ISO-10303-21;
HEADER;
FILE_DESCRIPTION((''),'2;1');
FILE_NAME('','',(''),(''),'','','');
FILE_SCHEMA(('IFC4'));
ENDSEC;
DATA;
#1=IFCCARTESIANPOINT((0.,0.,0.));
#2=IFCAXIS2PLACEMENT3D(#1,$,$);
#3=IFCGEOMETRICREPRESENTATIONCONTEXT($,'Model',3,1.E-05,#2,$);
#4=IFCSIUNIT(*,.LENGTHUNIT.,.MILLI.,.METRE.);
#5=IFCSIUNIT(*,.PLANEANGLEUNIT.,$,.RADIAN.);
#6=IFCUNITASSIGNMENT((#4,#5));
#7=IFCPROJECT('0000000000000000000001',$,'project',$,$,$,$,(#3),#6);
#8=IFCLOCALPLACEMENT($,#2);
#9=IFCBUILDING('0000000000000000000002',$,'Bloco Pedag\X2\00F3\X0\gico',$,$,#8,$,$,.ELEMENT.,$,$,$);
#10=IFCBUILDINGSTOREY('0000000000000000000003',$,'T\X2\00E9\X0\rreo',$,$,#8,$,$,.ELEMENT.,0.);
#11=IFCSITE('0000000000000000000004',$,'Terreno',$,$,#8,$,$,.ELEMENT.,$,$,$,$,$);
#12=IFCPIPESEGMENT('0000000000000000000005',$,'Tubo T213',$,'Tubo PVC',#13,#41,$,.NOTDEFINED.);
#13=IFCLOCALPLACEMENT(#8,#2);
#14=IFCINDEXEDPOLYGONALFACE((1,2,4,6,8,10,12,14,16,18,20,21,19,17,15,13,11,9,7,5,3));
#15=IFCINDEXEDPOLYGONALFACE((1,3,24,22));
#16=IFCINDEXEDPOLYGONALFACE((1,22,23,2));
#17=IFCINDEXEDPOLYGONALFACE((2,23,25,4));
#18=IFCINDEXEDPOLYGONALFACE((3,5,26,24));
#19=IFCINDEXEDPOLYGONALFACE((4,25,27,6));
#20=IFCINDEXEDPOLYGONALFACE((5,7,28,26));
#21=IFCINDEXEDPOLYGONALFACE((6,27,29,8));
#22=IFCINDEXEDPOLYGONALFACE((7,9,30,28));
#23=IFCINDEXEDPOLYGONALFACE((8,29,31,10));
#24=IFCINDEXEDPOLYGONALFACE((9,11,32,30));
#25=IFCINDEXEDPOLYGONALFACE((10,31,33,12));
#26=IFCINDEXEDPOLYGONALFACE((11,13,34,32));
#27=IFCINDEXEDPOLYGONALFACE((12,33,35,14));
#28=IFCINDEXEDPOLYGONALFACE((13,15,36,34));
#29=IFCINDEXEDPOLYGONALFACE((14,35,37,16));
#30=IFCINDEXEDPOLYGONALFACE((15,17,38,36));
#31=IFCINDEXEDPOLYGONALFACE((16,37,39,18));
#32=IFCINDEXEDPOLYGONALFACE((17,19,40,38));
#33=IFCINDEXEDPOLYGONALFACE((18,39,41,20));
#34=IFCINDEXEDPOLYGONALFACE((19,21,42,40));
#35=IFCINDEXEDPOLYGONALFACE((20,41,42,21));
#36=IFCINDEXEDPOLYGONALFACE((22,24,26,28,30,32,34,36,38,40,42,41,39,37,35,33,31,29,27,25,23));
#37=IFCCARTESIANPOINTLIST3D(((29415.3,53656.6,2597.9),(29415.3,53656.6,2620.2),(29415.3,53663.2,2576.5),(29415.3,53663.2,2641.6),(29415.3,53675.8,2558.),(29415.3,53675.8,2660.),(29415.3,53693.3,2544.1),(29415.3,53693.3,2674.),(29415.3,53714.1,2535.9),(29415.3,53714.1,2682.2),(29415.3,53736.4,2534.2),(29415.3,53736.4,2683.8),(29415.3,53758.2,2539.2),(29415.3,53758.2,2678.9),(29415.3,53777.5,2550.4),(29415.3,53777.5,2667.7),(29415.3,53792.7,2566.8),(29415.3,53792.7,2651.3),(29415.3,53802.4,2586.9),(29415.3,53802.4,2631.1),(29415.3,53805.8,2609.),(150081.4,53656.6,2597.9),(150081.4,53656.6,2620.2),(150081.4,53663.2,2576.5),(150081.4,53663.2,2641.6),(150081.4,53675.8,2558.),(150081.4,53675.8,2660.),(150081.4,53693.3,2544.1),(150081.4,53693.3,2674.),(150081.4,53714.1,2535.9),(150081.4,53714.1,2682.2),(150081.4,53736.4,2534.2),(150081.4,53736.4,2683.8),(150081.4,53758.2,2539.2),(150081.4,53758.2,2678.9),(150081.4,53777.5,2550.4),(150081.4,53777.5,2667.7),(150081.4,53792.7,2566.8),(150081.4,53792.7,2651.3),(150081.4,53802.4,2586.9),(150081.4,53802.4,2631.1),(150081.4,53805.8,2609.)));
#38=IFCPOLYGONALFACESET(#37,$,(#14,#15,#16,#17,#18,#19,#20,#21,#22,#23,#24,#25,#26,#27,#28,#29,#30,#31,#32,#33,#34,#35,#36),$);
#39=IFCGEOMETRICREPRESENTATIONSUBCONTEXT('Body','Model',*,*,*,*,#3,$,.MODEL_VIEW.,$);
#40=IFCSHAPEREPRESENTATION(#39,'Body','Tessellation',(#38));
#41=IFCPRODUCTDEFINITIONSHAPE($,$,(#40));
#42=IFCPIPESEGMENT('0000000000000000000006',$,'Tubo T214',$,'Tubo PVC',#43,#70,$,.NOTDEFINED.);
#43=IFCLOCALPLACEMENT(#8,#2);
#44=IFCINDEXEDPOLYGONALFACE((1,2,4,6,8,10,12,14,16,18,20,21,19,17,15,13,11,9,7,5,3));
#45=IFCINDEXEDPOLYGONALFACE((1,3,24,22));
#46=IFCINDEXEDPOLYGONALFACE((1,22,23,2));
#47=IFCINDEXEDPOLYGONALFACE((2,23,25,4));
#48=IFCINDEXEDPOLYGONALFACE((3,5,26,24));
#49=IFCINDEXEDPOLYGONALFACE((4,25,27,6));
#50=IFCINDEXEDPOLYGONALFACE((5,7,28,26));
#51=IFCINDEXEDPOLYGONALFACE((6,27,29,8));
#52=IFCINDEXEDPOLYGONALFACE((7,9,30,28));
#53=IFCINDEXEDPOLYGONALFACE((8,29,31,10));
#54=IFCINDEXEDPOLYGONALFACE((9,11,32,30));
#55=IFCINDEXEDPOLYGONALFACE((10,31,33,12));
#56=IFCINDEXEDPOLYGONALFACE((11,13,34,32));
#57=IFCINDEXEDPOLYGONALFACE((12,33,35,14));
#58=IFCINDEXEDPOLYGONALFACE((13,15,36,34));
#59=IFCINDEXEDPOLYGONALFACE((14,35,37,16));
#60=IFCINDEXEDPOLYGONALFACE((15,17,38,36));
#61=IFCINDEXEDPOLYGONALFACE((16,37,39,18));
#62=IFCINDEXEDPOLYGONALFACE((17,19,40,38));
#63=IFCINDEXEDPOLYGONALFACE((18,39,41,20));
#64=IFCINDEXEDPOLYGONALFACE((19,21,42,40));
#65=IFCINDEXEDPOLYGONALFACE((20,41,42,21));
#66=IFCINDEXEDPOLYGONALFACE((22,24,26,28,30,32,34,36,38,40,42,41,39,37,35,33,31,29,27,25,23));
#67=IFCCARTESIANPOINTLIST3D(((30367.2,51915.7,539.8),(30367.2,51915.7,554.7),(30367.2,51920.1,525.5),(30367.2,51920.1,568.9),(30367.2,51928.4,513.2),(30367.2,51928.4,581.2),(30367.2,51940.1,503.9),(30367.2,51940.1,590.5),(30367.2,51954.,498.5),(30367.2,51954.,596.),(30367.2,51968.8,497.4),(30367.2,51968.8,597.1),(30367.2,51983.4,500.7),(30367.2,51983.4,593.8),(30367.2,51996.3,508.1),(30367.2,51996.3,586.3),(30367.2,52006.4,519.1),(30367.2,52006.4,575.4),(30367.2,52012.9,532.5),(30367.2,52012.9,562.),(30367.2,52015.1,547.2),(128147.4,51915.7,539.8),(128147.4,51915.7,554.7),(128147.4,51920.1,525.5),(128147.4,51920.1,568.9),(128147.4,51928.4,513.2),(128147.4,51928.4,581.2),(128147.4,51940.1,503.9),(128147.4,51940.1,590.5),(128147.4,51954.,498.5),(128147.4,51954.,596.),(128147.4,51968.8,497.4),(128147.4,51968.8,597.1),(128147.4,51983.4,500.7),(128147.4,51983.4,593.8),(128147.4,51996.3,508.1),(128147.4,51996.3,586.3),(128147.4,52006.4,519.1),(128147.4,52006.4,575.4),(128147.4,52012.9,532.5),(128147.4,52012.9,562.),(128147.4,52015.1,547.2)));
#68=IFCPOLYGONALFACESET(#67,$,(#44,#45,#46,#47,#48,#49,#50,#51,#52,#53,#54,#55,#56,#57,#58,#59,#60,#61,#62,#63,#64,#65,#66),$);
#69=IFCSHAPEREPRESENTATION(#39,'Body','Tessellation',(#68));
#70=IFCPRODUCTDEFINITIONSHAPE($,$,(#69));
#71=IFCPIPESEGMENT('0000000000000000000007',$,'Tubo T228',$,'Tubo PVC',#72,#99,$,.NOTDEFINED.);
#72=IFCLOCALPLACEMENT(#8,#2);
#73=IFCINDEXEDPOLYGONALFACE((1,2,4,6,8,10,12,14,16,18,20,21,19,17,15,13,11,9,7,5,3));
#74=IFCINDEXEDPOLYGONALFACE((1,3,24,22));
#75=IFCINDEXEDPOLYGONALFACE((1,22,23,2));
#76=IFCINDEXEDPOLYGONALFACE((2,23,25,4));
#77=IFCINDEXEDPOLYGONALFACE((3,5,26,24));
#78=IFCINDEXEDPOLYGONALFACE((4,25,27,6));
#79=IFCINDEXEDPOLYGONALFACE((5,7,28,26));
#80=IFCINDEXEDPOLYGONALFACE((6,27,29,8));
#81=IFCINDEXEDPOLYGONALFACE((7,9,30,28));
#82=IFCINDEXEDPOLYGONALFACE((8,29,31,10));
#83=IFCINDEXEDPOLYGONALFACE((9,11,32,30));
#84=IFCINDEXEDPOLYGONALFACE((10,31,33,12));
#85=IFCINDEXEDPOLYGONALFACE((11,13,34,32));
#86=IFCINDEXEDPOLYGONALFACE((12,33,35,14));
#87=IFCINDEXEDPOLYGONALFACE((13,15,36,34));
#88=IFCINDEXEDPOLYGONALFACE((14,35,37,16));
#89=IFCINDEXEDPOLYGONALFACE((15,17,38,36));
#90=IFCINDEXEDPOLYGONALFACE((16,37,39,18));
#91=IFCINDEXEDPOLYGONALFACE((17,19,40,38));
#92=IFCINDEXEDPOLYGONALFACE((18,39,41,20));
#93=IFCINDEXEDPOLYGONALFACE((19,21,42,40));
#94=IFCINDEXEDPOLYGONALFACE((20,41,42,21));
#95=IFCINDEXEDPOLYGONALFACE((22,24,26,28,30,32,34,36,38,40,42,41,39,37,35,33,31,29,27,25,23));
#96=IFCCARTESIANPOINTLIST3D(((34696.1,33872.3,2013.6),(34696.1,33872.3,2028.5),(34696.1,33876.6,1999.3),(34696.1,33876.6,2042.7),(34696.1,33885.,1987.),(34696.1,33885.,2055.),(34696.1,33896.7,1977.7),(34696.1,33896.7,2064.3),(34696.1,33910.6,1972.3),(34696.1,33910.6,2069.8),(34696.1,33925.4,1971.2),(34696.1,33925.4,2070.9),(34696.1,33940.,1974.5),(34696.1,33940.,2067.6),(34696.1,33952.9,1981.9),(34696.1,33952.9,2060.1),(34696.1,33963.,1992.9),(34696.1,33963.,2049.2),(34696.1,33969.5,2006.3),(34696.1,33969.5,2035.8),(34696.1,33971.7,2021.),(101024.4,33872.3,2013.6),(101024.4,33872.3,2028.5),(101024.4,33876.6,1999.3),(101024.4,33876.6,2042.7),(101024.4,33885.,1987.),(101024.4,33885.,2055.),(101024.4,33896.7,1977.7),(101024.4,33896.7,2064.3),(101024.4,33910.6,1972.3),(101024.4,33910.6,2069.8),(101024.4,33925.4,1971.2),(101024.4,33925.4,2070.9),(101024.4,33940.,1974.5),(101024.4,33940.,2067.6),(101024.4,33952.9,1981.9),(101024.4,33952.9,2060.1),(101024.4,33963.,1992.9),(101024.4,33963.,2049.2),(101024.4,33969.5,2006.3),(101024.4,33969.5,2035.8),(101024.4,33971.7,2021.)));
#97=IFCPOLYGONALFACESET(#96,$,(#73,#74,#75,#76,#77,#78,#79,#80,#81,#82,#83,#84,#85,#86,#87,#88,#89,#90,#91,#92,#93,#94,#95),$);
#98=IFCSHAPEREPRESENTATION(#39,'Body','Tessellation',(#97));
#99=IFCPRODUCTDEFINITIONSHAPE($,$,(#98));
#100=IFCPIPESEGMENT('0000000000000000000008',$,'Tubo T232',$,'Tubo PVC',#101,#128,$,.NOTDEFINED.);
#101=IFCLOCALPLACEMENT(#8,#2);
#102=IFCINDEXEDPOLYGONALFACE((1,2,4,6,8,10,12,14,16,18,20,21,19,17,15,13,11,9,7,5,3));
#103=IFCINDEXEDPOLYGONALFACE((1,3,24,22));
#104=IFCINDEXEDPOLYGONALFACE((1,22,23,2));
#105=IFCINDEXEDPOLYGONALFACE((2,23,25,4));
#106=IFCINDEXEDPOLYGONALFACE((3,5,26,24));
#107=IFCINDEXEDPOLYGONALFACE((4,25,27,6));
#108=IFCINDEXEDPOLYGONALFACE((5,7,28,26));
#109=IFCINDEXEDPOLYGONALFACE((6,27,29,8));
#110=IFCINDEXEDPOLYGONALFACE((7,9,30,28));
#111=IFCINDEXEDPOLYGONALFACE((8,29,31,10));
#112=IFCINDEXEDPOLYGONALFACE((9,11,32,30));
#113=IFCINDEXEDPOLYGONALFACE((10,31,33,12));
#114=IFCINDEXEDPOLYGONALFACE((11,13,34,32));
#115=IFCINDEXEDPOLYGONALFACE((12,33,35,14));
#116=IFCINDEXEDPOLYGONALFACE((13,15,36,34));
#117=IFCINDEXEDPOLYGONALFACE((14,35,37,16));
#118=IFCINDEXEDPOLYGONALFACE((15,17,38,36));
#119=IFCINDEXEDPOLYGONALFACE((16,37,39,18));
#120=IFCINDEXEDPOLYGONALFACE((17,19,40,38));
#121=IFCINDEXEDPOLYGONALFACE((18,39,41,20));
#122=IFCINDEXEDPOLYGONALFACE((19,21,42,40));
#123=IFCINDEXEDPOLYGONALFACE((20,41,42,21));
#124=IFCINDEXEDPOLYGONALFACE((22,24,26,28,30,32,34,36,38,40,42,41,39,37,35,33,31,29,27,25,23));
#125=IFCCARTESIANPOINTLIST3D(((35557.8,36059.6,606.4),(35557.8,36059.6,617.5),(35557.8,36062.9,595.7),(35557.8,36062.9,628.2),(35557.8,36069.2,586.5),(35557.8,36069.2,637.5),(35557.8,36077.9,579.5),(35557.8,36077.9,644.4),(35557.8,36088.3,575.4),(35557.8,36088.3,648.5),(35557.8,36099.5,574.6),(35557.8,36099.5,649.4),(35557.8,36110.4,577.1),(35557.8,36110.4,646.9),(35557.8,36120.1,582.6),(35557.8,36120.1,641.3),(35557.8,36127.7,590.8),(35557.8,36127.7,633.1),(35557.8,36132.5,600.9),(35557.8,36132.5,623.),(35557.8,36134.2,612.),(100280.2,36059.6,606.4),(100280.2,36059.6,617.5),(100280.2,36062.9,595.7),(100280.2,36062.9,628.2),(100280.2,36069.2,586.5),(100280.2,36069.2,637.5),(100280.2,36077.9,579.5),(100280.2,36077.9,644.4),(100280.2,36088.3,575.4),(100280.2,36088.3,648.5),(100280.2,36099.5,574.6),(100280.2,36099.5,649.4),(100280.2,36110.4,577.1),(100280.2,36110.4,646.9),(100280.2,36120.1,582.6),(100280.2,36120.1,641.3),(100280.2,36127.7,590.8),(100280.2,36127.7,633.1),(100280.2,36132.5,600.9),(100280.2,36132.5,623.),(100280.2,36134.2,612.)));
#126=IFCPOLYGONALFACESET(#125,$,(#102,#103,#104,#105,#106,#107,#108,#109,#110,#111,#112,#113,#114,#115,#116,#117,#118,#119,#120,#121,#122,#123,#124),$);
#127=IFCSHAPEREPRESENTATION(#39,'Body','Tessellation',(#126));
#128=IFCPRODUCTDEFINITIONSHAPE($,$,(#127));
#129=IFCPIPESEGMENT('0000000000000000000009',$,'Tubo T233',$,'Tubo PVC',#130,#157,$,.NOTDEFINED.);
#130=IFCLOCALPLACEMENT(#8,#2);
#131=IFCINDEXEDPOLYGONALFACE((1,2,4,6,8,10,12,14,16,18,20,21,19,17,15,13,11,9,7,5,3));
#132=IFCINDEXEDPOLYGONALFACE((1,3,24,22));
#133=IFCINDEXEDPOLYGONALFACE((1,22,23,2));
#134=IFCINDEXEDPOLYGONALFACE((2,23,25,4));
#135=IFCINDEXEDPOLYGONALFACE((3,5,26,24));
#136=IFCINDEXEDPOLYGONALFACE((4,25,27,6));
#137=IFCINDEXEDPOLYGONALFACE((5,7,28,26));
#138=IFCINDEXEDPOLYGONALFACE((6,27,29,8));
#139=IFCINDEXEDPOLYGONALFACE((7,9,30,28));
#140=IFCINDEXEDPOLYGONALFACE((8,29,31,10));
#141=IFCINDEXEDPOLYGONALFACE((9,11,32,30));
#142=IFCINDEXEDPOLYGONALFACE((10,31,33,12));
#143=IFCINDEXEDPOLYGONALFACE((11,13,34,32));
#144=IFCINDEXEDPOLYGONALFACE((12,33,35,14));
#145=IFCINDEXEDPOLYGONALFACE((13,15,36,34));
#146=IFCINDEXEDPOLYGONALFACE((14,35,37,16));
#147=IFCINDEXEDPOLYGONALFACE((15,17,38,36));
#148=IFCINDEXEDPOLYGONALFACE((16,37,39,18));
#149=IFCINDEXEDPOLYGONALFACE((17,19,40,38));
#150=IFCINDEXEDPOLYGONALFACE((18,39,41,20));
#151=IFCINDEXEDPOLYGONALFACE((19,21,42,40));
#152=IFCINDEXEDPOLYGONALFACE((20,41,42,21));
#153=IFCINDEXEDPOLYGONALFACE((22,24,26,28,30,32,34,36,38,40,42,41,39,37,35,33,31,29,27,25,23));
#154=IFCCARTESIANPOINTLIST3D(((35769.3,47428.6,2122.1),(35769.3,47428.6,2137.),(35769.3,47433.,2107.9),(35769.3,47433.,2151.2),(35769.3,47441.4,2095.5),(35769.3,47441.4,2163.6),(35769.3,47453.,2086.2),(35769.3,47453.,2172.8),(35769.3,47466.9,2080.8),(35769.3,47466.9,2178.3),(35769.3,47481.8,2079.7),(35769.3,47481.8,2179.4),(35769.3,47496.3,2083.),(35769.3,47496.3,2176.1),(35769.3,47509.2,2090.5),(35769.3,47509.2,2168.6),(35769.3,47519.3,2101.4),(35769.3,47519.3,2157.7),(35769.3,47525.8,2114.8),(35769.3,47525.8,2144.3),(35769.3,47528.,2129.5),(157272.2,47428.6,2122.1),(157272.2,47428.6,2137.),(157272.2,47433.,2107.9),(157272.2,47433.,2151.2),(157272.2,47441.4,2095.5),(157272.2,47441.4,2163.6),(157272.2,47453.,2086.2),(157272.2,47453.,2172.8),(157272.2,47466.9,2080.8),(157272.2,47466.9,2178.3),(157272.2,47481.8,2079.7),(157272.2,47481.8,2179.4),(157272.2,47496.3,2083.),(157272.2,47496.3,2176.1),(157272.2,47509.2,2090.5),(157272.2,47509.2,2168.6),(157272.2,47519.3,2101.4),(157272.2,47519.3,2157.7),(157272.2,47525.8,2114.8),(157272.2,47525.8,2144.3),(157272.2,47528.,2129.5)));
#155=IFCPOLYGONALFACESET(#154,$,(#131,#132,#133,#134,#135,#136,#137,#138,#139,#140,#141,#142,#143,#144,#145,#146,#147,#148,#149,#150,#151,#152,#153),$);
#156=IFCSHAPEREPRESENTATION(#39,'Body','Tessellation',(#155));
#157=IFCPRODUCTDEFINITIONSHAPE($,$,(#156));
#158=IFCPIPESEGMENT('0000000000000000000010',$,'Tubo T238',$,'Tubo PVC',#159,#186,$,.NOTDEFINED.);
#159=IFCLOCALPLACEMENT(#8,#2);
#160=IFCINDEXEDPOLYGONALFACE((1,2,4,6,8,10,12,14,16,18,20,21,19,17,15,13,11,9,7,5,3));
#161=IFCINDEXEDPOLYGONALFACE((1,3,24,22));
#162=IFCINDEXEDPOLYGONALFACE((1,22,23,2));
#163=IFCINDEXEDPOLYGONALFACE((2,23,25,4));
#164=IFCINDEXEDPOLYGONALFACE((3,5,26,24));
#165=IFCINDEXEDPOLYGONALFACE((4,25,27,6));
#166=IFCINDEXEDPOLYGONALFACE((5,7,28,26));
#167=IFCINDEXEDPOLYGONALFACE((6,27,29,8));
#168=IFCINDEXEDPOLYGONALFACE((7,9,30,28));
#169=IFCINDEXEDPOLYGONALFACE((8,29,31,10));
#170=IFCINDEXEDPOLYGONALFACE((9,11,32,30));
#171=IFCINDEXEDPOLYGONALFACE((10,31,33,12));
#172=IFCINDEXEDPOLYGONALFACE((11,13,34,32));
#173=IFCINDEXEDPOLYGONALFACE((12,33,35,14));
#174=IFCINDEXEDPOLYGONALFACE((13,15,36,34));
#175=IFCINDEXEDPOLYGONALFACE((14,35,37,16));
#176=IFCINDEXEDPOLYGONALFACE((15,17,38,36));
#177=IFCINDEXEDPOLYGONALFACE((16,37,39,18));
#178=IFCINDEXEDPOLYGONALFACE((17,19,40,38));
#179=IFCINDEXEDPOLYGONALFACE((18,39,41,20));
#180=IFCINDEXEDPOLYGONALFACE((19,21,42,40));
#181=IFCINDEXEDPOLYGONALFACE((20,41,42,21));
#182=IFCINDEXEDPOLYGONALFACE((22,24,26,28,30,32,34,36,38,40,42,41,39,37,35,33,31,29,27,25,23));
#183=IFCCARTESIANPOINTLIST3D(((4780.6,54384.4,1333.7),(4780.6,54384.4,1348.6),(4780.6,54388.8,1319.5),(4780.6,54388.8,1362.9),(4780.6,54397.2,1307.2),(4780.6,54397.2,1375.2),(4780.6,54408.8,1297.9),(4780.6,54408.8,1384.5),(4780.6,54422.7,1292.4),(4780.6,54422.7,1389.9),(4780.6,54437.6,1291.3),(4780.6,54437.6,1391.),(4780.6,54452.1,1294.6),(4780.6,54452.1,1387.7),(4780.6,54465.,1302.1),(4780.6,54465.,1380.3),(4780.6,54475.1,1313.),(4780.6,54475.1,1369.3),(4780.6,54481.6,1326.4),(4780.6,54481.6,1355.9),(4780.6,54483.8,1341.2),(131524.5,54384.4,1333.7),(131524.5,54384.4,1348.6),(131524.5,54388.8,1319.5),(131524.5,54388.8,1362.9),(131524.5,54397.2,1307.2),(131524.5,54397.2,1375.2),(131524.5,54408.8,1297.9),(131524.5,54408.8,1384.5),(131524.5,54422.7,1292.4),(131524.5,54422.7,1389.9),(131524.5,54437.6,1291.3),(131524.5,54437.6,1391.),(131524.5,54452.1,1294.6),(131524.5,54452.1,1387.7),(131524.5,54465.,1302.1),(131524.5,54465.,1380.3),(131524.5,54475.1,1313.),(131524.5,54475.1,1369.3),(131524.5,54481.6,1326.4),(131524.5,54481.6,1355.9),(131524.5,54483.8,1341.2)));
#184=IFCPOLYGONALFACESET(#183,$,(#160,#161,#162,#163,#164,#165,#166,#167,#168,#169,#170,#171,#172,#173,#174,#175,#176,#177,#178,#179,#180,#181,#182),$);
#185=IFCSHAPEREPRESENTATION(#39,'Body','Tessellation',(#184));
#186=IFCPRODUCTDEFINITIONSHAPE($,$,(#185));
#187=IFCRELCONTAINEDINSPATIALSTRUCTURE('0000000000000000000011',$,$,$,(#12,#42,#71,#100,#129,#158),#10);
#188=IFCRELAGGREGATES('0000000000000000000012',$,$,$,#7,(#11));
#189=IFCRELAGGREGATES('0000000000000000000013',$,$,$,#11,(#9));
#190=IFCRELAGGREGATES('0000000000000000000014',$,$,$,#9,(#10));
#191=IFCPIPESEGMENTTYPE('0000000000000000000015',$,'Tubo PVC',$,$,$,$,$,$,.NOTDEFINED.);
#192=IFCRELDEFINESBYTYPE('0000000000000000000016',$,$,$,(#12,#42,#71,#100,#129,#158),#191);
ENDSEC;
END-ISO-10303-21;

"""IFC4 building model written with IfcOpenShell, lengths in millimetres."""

from ifc_helpers import new_model, si_unit, frame, origin, origin_2d, place, context, subcontext, project, spatial, circle, extrude, type_object, element, save


model = new_model("IFC4")

# Units and contexts
model_context = context("Model", 3, precision=1e-05, world=origin())
body_context = subcontext(model_context, "Body", "Model", "MODEL_VIEW")
ifc_project = project(units=[si_unit("LENGTHUNIT", "METRE", prefix="MILLI"), si_unit("PLANEANGLEUNIT", "RADIAN")], contexts=[model_context])

# Site, building, storey
placement = place(None, origin())
site = spatial("IfcSite", under=ifc_project, at=placement, Name="Terreno", CompositionType="ELEMENT")
building = spatial("IfcBuilding", under=site, at=placement, Name="Bloco Pedagógico", CompositionType="ELEMENT")
storey = spatial("IfcBuildingStorey", under=building, at=placement, Name="Térreo", CompositionType="ELEMENT", Elevation=0.0)

# Pipe segments
pipe_segment_type = type_object("IfcPipeSegmentType", Name="Tubo PVC", PredefinedType="NOTDEFINED")
pipe_segment_1_placement = place(None, frame((29415.3, 53730.8, 2609.0), z_axis=(1.0, 0.0, 0.0), x_axis=(0.0, 1.0, 0.0)))
element("IfcPipeSegment", 1, at=pipe_segment_1_placement, inside=storey, type_object=pipe_segment_type, Name="Tubo T213", ObjectType="Tubo PVC", PredefinedType="NOTDEFINED", context=body_context, shape_type="SweptSolid", body=[
    extrude(circle(Radius=75.0, at=origin_2d()), None, (0.0, 0.0, 1.0), 120666.1),
])
pipe_segment_2_placement = place(None, frame((30367.2, 51965.1, 547.2), z_axis=(1.0, 0.0, 0.0), x_axis=(0.0, 1.0, 0.0)))
element("IfcPipeSegment", 2, at=pipe_segment_2_placement, inside=storey, type_object=pipe_segment_type, Name="Tubo T214", ObjectType="Tubo PVC", PredefinedType="NOTDEFINED", context=body_context, shape_type="SweptSolid", body=[
    extrude(circle(Radius=50.0, at=origin_2d()), None, (0.0, 0.0, 1.0), 97780.2),
])
pipe_segment_3_placement = place(None, frame((34696.1, 33921.7, 2021.0), z_axis=(1.0, 0.0, 0.0), x_axis=(0.0, 1.0, 0.0)))
element("IfcPipeSegment", 3, at=pipe_segment_3_placement, inside=storey, type_object=pipe_segment_type, Name="Tubo T228", ObjectType="Tubo PVC", PredefinedType="NOTDEFINED", context=body_context, shape_type="SweptSolid", body=[
    extrude(circle(Radius=50.0, at=origin_2d()), None, (0.0, 0.0, 1.0), 66328.2),
])
pipe_segment_4_placement = place(None, frame((35557.8, 36096.7, 612.0), z_axis=(1.0, 0.0, 0.0), x_axis=(0.0, 1.0, 0.0)))
element("IfcPipeSegment", 4, at=pipe_segment_4_placement, inside=storey, type_object=pipe_segment_type, Name="Tubo T232", ObjectType="Tubo PVC", PredefinedType="NOTDEFINED", context=body_context, shape_type="SweptSolid", body=[
    extrude(circle(Radius=37.5, at=origin_2d()), None, (0.0, 0.0, 1.0), 64722.4),
])
pipe_segment_5_placement = place(None, frame((35769.3, 47478.0, 2129.5), z_axis=(1.0, 0.0, 0.0), x_axis=(0.0, 1.0, 0.0)))
element("IfcPipeSegment", 5, at=pipe_segment_5_placement, inside=storey, type_object=pipe_segment_type, Name="Tubo T233", ObjectType="Tubo PVC", PredefinedType="NOTDEFINED", context=body_context, shape_type="SweptSolid", body=[
    extrude(circle(Radius=50.0, at=origin_2d()), None, (0.0, 0.0, 1.0), 121502.9),
])
pipe_segment_6_placement = place(None, frame((4780.6, 54433.8, 1341.2), z_axis=(1.0, 0.0, 0.0), x_axis=(0.0, 1.0, 0.0)))
element("IfcPipeSegment", 6, at=pipe_segment_6_placement, inside=storey, type_object=pipe_segment_type, Name="Tubo T238", ObjectType="Tubo PVC", PredefinedType="NOTDEFINED", context=body_context, shape_type="SweptSolid", body=[
    extrude(circle(Radius=50.0, at=origin_2d()), None, (0.0, 0.0, 1.0), 126743.9),
])

save(model, "model.ifc")
